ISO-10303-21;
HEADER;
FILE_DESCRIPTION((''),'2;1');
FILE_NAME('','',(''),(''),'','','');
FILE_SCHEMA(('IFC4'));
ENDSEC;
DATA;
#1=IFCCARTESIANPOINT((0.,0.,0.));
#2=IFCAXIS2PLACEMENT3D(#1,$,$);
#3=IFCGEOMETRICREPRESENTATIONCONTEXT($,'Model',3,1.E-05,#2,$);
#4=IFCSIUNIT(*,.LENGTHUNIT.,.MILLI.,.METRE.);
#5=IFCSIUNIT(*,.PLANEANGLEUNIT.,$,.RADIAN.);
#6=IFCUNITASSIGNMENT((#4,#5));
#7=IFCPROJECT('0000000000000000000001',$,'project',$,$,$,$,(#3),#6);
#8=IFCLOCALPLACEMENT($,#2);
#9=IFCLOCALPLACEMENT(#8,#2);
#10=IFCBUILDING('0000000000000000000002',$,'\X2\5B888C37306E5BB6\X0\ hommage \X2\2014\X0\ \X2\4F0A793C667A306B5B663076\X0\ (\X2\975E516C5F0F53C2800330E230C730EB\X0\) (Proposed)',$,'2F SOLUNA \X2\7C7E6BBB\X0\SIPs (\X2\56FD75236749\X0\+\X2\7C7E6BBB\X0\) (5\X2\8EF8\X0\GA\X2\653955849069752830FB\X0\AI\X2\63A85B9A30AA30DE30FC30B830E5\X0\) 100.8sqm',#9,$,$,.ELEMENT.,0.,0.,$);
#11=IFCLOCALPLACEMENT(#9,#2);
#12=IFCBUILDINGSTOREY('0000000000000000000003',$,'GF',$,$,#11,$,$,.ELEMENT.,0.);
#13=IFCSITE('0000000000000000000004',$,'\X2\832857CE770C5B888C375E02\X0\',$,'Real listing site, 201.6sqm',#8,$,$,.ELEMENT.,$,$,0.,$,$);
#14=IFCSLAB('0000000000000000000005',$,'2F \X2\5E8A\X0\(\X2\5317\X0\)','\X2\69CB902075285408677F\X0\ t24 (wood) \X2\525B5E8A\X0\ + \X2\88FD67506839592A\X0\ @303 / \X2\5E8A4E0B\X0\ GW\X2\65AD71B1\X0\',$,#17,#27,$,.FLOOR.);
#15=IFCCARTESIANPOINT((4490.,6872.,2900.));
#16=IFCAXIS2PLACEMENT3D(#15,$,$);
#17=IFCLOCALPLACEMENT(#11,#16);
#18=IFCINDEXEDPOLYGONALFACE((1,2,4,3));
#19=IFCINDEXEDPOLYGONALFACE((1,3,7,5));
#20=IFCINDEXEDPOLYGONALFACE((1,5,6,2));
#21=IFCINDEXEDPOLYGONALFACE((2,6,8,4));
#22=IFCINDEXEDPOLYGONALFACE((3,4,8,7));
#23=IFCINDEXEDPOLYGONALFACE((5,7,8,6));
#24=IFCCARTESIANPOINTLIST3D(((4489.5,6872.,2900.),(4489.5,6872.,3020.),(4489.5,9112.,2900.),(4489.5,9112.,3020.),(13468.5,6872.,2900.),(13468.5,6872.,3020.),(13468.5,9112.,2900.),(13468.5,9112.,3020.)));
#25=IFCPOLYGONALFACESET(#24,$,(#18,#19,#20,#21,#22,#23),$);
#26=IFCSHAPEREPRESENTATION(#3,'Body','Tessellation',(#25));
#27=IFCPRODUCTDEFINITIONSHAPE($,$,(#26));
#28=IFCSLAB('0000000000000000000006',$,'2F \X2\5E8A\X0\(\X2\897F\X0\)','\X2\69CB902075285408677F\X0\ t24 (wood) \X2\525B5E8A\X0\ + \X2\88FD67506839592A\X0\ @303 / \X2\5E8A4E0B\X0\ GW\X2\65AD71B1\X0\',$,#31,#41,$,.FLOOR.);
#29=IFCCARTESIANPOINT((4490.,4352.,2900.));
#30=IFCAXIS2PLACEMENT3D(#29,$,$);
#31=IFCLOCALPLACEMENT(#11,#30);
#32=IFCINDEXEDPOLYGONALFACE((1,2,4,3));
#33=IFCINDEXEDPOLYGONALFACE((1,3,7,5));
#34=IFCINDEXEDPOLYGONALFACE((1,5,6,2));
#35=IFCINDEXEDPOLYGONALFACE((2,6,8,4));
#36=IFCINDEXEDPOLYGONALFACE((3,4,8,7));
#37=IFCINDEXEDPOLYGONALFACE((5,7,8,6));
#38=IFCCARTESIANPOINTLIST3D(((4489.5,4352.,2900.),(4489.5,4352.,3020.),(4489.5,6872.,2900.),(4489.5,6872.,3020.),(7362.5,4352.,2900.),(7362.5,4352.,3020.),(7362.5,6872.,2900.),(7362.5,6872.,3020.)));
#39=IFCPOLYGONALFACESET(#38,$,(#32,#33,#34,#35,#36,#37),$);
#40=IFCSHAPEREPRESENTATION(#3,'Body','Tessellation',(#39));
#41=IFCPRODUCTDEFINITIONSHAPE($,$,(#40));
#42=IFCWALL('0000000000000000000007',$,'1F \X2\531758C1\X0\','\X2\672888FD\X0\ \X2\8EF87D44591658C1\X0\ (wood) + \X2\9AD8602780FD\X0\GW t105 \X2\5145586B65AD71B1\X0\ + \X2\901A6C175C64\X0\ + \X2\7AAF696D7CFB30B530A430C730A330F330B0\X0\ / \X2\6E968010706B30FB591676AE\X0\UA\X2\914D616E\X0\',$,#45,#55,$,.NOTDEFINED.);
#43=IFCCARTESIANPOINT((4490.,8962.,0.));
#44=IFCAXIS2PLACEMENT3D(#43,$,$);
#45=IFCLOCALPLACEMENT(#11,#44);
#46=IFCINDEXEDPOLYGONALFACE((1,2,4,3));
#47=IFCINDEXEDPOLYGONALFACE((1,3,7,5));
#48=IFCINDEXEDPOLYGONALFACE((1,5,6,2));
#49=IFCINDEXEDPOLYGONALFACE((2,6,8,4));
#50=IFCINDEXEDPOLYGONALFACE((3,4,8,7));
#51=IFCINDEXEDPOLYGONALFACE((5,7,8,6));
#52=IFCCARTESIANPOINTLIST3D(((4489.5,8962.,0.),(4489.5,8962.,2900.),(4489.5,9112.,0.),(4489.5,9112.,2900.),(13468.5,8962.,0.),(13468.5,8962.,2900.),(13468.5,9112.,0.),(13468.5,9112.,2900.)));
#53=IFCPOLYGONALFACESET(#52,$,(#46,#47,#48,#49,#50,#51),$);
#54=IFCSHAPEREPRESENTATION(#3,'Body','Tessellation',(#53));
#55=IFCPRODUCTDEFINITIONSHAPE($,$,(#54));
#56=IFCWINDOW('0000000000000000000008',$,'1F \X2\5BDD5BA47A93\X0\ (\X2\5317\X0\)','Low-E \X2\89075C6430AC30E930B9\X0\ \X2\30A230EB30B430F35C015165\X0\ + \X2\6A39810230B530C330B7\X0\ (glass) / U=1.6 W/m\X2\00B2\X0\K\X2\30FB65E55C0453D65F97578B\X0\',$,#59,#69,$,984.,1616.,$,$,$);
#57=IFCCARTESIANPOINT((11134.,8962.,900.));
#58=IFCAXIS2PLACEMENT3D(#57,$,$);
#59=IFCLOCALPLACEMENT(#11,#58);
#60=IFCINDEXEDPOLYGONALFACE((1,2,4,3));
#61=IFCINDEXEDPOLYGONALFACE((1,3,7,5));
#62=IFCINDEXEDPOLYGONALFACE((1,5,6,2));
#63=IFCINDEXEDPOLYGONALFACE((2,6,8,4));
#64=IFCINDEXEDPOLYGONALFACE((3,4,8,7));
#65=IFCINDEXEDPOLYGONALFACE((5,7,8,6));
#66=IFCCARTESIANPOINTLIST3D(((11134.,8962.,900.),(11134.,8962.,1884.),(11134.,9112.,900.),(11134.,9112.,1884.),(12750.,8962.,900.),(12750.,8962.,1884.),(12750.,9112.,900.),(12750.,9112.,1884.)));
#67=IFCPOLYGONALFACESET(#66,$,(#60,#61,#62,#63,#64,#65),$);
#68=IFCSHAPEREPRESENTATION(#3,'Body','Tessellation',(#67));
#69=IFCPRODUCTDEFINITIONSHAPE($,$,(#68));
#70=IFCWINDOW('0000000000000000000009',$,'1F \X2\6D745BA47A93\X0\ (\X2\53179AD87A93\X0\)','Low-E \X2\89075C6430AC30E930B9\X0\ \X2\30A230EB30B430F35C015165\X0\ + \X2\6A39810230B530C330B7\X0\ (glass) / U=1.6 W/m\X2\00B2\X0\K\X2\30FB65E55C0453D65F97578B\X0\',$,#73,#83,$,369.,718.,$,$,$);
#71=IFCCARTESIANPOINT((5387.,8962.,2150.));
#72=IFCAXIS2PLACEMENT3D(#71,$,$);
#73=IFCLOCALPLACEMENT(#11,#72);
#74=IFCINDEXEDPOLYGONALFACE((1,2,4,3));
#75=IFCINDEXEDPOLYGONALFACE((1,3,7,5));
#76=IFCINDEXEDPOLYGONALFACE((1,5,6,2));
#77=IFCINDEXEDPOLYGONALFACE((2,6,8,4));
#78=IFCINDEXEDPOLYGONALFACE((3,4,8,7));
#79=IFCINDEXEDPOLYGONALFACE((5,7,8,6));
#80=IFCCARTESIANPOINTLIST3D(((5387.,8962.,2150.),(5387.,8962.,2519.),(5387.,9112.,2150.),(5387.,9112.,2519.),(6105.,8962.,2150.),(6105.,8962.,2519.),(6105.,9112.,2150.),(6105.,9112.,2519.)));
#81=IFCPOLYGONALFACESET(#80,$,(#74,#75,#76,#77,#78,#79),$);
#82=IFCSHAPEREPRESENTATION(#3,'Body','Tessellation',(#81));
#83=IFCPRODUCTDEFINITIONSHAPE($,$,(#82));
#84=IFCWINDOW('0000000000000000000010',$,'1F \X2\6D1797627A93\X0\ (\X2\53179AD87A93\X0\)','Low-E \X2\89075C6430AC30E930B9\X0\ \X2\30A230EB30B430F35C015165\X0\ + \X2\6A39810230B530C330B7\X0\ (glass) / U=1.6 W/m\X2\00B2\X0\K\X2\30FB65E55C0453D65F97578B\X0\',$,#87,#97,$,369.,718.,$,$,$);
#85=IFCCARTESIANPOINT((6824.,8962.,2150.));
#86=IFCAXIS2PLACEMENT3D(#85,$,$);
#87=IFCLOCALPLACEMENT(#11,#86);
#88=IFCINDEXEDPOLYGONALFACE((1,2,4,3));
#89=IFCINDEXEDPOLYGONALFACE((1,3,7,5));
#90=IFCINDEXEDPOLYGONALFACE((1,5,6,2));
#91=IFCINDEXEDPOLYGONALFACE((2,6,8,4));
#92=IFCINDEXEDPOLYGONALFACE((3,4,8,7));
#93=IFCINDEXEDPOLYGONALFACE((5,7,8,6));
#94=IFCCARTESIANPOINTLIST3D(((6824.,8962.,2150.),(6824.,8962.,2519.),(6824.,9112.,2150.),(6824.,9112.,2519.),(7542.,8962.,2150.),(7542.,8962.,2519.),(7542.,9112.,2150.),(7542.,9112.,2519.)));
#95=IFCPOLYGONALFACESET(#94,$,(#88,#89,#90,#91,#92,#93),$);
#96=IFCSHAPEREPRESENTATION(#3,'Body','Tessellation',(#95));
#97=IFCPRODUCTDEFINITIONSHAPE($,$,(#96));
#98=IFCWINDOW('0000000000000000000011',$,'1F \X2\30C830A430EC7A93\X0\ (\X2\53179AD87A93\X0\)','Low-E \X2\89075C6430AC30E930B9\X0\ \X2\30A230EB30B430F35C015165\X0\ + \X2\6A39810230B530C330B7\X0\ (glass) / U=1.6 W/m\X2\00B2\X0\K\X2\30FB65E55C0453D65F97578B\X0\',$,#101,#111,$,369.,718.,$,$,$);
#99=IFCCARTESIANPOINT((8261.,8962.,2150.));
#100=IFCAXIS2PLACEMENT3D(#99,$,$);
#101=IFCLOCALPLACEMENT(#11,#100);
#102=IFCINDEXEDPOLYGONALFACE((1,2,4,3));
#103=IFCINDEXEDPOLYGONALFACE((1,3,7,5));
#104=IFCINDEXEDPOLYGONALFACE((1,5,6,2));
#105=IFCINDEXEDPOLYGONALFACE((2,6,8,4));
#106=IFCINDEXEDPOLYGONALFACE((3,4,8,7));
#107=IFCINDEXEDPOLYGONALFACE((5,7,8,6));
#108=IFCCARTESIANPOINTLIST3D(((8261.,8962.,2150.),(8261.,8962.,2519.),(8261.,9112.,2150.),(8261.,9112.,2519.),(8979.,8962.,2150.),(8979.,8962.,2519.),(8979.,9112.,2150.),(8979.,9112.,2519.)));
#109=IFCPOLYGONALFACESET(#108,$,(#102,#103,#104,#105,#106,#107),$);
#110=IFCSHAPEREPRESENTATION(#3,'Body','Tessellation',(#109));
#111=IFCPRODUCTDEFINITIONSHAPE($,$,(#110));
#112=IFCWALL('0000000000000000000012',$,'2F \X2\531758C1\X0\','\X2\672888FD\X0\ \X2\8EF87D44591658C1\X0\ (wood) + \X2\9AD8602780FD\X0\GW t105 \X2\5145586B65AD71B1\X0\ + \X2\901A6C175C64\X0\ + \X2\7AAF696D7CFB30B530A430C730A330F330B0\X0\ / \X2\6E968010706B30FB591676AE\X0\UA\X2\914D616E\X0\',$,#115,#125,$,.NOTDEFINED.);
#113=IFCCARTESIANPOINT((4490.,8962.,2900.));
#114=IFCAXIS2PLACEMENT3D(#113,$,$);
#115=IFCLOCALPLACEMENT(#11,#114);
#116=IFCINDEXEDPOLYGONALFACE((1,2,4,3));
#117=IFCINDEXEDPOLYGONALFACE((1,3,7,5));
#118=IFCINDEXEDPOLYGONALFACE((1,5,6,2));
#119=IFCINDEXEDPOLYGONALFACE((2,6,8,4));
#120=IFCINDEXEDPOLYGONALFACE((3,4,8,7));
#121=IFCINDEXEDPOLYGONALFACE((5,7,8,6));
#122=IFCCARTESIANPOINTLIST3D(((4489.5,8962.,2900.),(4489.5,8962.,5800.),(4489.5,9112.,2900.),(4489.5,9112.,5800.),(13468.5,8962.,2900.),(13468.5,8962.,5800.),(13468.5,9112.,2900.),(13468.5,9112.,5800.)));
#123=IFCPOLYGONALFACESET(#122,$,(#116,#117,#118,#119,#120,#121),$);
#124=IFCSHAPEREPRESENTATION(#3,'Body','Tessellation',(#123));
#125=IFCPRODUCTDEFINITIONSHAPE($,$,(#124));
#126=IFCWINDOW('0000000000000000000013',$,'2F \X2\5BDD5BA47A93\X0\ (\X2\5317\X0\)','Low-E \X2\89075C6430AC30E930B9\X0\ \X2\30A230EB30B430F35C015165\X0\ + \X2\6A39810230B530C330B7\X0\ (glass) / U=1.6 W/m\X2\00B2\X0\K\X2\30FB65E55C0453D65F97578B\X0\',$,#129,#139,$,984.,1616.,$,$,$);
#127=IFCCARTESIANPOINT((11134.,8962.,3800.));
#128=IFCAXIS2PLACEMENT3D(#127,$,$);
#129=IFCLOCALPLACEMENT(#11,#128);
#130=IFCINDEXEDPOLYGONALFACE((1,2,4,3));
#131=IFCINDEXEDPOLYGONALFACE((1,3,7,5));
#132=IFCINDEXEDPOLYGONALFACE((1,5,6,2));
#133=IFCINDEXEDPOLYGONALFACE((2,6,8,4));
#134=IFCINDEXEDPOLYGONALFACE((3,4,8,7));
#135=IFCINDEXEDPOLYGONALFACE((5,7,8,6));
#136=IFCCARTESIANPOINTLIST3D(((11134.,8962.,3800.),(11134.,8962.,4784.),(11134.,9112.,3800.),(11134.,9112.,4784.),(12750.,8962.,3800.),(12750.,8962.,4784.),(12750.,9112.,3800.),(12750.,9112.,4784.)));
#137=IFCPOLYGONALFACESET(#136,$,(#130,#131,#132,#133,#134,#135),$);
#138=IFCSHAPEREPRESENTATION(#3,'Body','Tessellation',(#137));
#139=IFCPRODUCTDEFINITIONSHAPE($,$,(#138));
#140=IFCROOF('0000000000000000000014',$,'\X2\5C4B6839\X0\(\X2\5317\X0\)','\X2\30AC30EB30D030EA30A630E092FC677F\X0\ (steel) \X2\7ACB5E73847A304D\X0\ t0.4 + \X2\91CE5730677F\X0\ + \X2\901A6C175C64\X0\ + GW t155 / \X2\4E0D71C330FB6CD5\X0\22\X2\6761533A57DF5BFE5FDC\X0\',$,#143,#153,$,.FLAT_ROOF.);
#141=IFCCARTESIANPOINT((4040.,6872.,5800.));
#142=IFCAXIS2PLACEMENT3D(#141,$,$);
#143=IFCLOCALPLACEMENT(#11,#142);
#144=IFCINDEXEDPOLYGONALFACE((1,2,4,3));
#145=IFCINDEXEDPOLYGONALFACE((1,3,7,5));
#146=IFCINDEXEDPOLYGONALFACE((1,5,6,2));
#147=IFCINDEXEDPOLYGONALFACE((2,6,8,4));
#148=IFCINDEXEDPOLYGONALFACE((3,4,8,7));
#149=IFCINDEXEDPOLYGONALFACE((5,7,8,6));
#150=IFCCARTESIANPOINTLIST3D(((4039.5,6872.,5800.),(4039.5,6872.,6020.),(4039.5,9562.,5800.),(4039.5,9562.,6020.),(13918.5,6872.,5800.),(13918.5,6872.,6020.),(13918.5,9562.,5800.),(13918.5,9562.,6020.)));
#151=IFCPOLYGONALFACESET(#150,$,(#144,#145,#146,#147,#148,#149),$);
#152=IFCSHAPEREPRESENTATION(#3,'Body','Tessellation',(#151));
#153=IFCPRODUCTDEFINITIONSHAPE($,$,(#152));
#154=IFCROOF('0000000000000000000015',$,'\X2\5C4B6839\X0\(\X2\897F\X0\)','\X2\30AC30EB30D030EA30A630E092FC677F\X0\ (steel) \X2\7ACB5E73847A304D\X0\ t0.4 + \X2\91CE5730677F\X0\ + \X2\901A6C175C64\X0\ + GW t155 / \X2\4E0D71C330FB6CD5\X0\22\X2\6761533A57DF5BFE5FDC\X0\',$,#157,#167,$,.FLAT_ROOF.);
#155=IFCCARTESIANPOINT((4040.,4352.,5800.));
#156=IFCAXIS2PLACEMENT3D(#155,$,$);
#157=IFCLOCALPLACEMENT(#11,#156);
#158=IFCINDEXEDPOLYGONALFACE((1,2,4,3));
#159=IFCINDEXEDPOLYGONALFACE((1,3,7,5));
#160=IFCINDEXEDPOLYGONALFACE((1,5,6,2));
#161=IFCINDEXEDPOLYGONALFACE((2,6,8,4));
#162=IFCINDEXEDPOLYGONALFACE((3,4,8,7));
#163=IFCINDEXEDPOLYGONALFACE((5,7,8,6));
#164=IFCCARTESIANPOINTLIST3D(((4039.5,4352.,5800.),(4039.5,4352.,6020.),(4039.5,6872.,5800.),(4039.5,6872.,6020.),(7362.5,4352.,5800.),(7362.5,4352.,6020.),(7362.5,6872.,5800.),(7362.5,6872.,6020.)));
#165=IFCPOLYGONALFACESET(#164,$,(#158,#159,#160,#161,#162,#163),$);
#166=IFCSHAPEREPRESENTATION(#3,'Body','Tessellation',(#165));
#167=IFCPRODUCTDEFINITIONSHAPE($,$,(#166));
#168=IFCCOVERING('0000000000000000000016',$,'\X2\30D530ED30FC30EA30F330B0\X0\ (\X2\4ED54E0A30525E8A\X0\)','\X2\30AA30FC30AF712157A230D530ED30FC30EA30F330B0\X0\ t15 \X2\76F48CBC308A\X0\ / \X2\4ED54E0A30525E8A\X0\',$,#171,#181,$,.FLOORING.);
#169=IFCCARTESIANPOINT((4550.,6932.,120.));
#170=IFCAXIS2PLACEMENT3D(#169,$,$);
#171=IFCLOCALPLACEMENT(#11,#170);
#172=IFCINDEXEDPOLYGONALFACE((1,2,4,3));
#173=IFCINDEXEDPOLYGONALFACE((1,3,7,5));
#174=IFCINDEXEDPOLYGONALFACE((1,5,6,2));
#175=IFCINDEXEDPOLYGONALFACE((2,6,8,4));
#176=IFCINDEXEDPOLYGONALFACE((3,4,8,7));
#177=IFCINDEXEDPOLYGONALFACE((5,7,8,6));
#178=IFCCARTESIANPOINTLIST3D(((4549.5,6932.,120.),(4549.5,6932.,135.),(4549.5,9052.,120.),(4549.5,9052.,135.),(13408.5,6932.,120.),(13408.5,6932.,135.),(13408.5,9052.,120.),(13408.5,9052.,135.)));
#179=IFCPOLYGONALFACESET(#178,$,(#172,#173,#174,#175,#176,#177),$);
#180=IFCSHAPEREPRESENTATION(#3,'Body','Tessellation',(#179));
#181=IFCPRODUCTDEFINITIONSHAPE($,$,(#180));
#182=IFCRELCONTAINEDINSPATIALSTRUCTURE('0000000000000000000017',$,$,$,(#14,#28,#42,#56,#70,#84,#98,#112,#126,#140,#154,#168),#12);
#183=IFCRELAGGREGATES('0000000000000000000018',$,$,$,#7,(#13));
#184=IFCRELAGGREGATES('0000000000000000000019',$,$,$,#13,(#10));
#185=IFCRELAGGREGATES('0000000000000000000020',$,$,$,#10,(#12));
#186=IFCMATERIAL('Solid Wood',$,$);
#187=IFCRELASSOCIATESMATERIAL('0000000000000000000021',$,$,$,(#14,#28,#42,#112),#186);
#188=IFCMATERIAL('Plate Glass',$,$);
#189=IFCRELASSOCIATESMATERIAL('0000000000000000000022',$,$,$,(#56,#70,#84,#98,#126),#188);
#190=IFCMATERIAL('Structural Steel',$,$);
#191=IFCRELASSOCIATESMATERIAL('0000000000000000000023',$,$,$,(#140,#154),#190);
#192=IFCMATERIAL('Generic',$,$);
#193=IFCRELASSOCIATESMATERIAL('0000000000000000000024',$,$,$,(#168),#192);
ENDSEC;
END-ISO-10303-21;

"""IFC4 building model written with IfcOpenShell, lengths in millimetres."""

from ifc_helpers import new_model, si_unit, frame, frame_2d, origin, place, context, project, spatial, rectangle, extrude, material, element, fill, save


model = new_model("IFC4")

# Units and contexts
model_context = context("Model", 3, precision=1e-05, world=origin())
ifc_project = project(units=[si_unit("LENGTHUNIT", "METRE", prefix="MILLI"), si_unit("PLANEANGLEUNIT", "RADIAN")], contexts=[model_context])

# Site, building, storey
site_placement = place(None, origin())
site = spatial("IfcSite", under=ifc_project, at=site_placement, Name="茨城県守谷市", ObjectType="Real listing site, 201.6sqm", CompositionType="ELEMENT", RefElevation=0.0)
building_placement = place(site_placement, origin())
building = spatial("IfcBuilding", under=site, at=building_placement, Name="守谷の家 hommage — 伊礼智に学ぶ (非公式参考モデル) (Proposed)", ObjectType="2F SOLUNA 籾殻SIPs (国産杉+籾殻) (5軸GA改善適用・AI推定オマージュ) 100.8sqm", CompositionType="ELEMENT", ElevationOfRefHeight=0.0, ElevationOfTerrain=0.0)
storey_placement = place(building_placement, origin())
storey = spatial("IfcBuildingStorey", under=building, at=storey_placement, Name="GF", CompositionType="ELEMENT", Elevation=0.0)

# Slabs
ifc_material_1 = material(Name="Solid Wood")
slab_1_placement = place(storey_placement, frame((4490.0, 6872.0, 2900.0)))
element("IfcSlab", 1, at=slab_1_placement, inside=storey, material=ifc_material_1, Name="2F 床(北)", Description="構造用合板 t24 (wood) 剛床 + 製材根太 @303 / 床下 GW断熱", PredefinedType="FLOOR", context=model_context, shape_type="SweptSolid", body=[
    extrude(rectangle(XDim=8979.0, YDim=2240.0, at=frame_2d((4489.0, 1120.0))), frame((4490.0, 6872.0, 2900.0)), (0.0, 0.0, 1.0), 120.0),
])
slab_2_placement = place(storey_placement, frame((4490.0, 4352.0, 2900.0)))
element("IfcSlab", 2, at=slab_2_placement, inside=storey, material=ifc_material_1, Name="2F 床(西)", Description="構造用合板 t24 (wood) 剛床 + 製材根太 @303 / 床下 GW断熱", PredefinedType="FLOOR", context=model_context, shape_type="SweptSolid", body=[
    extrude(rectangle(XDim=2873.0, YDim=2520.0, at=frame_2d((1436.0, 1260.0))), frame((4490.0, 4352.0, 2900.0)), (0.0, 0.0, 1.0), 120.0),
])

# Wall, openings, windows
wall_1_placement = place(storey_placement, frame((4490.0, 8962.0, 0.0)))
wall_1 = element("IfcWall", 3, at=wall_1_placement, inside=storey, material=ifc_material_1, Name="1F 北壁", Description="木製 軸組外壁 (wood) + 高性能GW t105 充填断熱 + 通気層 + 窯業系サイディング / 準耐火・外皮UA配慮", PredefinedType="NOTDEFINED", context=model_context, shape_type="SweptSolid", body=[
    extrude(rectangle(XDim=8979.0, YDim=150.0, at=frame_2d((4489.0, 75.0))), frame((4490.0, 8962.0, 0.0)), (0.0, 0.0, 1.0), 2900.0),
])
opening_1_placement = place(storey_placement, frame((11134.0, 8962.0, 900.0)))
opening_1 = element("IfcOpeningElement", 4, at=opening_1_placement, cuts=wall_1, PredefinedType="NOTDEFINED", context=model_context, shape_type="SweptSolid", body=[
    extrude(rectangle(XDim=1616.0, YDim=150.0, at=frame_2d((808.0, 75.0))), frame((11134.0, 8962.0, 900.0)), (0.0, 0.0, 1.0), 984.0),
])
opening_2_placement = place(storey_placement, frame((5387.0, 8962.0, 2150.0)))
opening_2 = element("IfcOpeningElement", 5, at=opening_2_placement, cuts=wall_1, PredefinedType="NOTDEFINED", context=model_context, shape_type="SweptSolid", body=[
    extrude(rectangle(XDim=718.0, YDim=150.0, at=frame_2d((359.0, 75.0))), frame((5387.0, 8962.0, 2150.0)), (0.0, 0.0, 1.0), 369.0),
])
opening_3_placement = place(storey_placement, frame((6824.0, 8962.0, 2150.0)))
opening_3 = element("IfcOpeningElement", 6, at=opening_3_placement, cuts=wall_1, PredefinedType="NOTDEFINED", context=model_context, shape_type="SweptSolid", body=[
    extrude(rectangle(XDim=718.0, YDim=150.0, at=frame_2d((359.0, 75.0))), frame((6824.0, 8962.0, 2150.0)), (0.0, 0.0, 1.0), 369.0),
])
opening_4_placement = place(storey_placement, frame((8261.0, 8962.0, 2150.0)))
opening_4 = element("IfcOpeningElement", 7, at=opening_4_placement, cuts=wall_1, PredefinedType="NOTDEFINED", context=model_context, shape_type="SweptSolid", body=[
    extrude(rectangle(XDim=718.0, YDim=150.0, at=frame_2d((359.0, 75.0))), frame((8261.0, 8962.0, 2150.0)), (0.0, 0.0, 1.0), 369.0),
])
ifc_material_2 = material(Name="Plate Glass")
window_1_placement = place(storey_placement, frame((11134.0, 8962.0, 900.0)))
window_1 = element("IfcWindow", 8, at=window_1_placement, inside=storey, material=ifc_material_2, Name="1F 寝室窓 (北)", Description="Low-E 複層ガラス アルゴン封入 + 樹脂サッシ (glass) / U=1.6 W/m²K・日射取得型", OverallHeight=984.0, OverallWidth=1616.0, context=model_context, shape_type="SweptSolid", body=[
    extrude(rectangle(XDim=1616.0, YDim=150.0, at=frame_2d((808.0, 75.0))), frame((11134.0, 8962.0, 900.0)), (0.0, 0.0, 1.0), 984.0),
])
fill(opening_1, window_1)
window_2_placement = place(storey_placement, frame((5387.0, 8962.0, 2150.0)))
window_2 = element("IfcWindow", 9, at=window_2_placement, inside=storey, material=ifc_material_2, Name="1F 浴室窓 (北高窓)", Description="Low-E 複層ガラス アルゴン封入 + 樹脂サッシ (glass) / U=1.6 W/m²K・日射取得型", OverallHeight=369.0, OverallWidth=718.0, context=model_context, shape_type="SweptSolid", body=[
    extrude(rectangle(XDim=718.0, YDim=150.0, at=frame_2d((359.0, 75.0))), frame((5387.0, 8962.0, 2150.0)), (0.0, 0.0, 1.0), 369.0),
])
fill(opening_2, window_2)
window_3_placement = place(storey_placement, frame((6824.0, 8962.0, 2150.0)))
window_3 = element("IfcWindow", 10, at=window_3_placement, inside=storey, material=ifc_material_2, Name="1F 洗面窓 (北高窓)", Description="Low-E 複層ガラス アルゴン封入 + 樹脂サッシ (glass) / U=1.6 W/m²K・日射取得型", OverallHeight=369.0, OverallWidth=718.0, context=model_context, shape_type="SweptSolid", body=[
    extrude(rectangle(XDim=718.0, YDim=150.0, at=frame_2d((359.0, 75.0))), frame((6824.0, 8962.0, 2150.0)), (0.0, 0.0, 1.0), 369.0),
])
fill(opening_3, window_3)
window_4_placement = place(storey_placement, frame((8261.0, 8962.0, 2150.0)))
window_4 = element("IfcWindow", 11, at=window_4_placement, inside=storey, material=ifc_material_2, Name="1F トイレ窓 (北高窓)", Description="Low-E 複層ガラス アルゴン封入 + 樹脂サッシ (glass) / U=1.6 W/m²K・日射取得型", OverallHeight=369.0, OverallWidth=718.0, context=model_context, shape_type="SweptSolid", body=[
    extrude(rectangle(XDim=718.0, YDim=150.0, at=frame_2d((359.0, 75.0))), frame((8261.0, 8962.0, 2150.0)), (0.0, 0.0, 1.0), 369.0),
])
fill(opening_4, window_4)

# Wall, opening, window
wall_2_placement = place(storey_placement, frame((4490.0, 8962.0, 2900.0)))
wall_2 = element("IfcWall", 12, at=wall_2_placement, inside=storey, material=ifc_material_1, Name="2F 北壁", Description="木製 軸組外壁 (wood) + 高性能GW t105 充填断熱 + 通気層 + 窯業系サイディング / 準耐火・外皮UA配慮", PredefinedType="NOTDEFINED", context=model_context, shape_type="SweptSolid", body=[
    extrude(rectangle(XDim=8979.0, YDim=150.0, at=frame_2d((4489.0, 75.0))), frame((4490.0, 8962.0, 2900.0)), (0.0, 0.0, 1.0), 2900.0),
])
opening_5_placement = place(storey_placement, frame((11134.0, 8962.0, 3800.0)))
opening_5 = element("IfcOpeningElement", 13, at=opening_5_placement, cuts=wall_2, PredefinedType="NOTDEFINED", context=model_context, shape_type="SweptSolid", body=[
    extrude(rectangle(XDim=1616.0, YDim=150.0, at=frame_2d((808.0, 75.0))), frame((11134.0, 8962.0, 3800.0)), (0.0, 0.0, 1.0), 984.0),
])
window_5_placement = place(storey_placement, frame((11134.0, 8962.0, 3800.0)))
window_5 = element("IfcWindow", 14, at=window_5_placement, inside=storey, material=ifc_material_2, Name="2F 寝室窓 (北)", Description="Low-E 複層ガラス アルゴン封入 + 樹脂サッシ (glass) / U=1.6 W/m²K・日射取得型", OverallHeight=984.0, OverallWidth=1616.0, context=model_context, shape_type="SweptSolid", body=[
    extrude(rectangle(XDim=1616.0, YDim=150.0, at=frame_2d((808.0, 75.0))), frame((11134.0, 8962.0, 3800.0)), (0.0, 0.0, 1.0), 984.0),
])
fill(opening_5, window_5)

# Roofs
ifc_material_3 = material(Name="Structural Steel")
for number, where, name in (
    (15, (4040.0, 6872.0, 5800.0), "屋根(北)"),
):
    element("IfcRoof", number, at=place(storey_placement, frame(where)), inside=storey, material=ifc_material_3, Name=name, Description="ガルバリウム鋼板 (steel) 立平葺き t0.4 + 野地板 + 通気層 + GW t155 / 不燃・法22条区域対応", PredefinedType="FLAT_ROOF", context=model_context, shape_type="SweptSolid", body=[
        extrude(rectangle(XDim=9879.0, YDim=2690.0, at=frame_2d((4939.0, 1345.0))), frame((4040.0, 6872.0, 5800.0)), (0.0, 0.0, 1.0), 220.0),
    ])
roof_placement = place(storey_placement, frame((4040.0, 4352.0, 5800.0)))
element("IfcRoof", 16, at=roof_placement, inside=storey, material=ifc_material_3, Name="屋根(西)", Description="ガルバリウム鋼板 (steel) 立平葺き t0.4 + 野地板 + 通気層 + GW t155 / 不燃・法22条区域対応", PredefinedType="FLAT_ROOF", context=model_context, shape_type="SweptSolid", body=[
    extrude(rectangle(XDim=3323.0, YDim=2520.0, at=frame_2d((1661.0, 1260.0))), frame((4040.0, 4352.0, 5800.0)), (0.0, 0.0, 1.0), 220.0),
])

# Covering
ifc_material_4 = material(Name="Generic")
covering_1_placement = place(storey_placement, frame((4550.0, 6932.0, 120.0)))
element("IfcCovering", 17, at=covering_1_placement, inside=storey, material=ifc_material_4, Name="フローリング (仕上げ床)", Description="オーク無垢フローリング t15 直貼り / 仕上げ床", PredefinedType="FLOORING", context=model_context, shape_type="SweptSolid", body=[
    extrude(rectangle(XDim=8859.0, YDim=2120.0, at=frame_2d((4429.0, 1060.0))), frame((4550.0, 6932.0, 120.0)), (0.0, 0.0, 1.0), 15.0),
])

save(model, "model.ifc")
